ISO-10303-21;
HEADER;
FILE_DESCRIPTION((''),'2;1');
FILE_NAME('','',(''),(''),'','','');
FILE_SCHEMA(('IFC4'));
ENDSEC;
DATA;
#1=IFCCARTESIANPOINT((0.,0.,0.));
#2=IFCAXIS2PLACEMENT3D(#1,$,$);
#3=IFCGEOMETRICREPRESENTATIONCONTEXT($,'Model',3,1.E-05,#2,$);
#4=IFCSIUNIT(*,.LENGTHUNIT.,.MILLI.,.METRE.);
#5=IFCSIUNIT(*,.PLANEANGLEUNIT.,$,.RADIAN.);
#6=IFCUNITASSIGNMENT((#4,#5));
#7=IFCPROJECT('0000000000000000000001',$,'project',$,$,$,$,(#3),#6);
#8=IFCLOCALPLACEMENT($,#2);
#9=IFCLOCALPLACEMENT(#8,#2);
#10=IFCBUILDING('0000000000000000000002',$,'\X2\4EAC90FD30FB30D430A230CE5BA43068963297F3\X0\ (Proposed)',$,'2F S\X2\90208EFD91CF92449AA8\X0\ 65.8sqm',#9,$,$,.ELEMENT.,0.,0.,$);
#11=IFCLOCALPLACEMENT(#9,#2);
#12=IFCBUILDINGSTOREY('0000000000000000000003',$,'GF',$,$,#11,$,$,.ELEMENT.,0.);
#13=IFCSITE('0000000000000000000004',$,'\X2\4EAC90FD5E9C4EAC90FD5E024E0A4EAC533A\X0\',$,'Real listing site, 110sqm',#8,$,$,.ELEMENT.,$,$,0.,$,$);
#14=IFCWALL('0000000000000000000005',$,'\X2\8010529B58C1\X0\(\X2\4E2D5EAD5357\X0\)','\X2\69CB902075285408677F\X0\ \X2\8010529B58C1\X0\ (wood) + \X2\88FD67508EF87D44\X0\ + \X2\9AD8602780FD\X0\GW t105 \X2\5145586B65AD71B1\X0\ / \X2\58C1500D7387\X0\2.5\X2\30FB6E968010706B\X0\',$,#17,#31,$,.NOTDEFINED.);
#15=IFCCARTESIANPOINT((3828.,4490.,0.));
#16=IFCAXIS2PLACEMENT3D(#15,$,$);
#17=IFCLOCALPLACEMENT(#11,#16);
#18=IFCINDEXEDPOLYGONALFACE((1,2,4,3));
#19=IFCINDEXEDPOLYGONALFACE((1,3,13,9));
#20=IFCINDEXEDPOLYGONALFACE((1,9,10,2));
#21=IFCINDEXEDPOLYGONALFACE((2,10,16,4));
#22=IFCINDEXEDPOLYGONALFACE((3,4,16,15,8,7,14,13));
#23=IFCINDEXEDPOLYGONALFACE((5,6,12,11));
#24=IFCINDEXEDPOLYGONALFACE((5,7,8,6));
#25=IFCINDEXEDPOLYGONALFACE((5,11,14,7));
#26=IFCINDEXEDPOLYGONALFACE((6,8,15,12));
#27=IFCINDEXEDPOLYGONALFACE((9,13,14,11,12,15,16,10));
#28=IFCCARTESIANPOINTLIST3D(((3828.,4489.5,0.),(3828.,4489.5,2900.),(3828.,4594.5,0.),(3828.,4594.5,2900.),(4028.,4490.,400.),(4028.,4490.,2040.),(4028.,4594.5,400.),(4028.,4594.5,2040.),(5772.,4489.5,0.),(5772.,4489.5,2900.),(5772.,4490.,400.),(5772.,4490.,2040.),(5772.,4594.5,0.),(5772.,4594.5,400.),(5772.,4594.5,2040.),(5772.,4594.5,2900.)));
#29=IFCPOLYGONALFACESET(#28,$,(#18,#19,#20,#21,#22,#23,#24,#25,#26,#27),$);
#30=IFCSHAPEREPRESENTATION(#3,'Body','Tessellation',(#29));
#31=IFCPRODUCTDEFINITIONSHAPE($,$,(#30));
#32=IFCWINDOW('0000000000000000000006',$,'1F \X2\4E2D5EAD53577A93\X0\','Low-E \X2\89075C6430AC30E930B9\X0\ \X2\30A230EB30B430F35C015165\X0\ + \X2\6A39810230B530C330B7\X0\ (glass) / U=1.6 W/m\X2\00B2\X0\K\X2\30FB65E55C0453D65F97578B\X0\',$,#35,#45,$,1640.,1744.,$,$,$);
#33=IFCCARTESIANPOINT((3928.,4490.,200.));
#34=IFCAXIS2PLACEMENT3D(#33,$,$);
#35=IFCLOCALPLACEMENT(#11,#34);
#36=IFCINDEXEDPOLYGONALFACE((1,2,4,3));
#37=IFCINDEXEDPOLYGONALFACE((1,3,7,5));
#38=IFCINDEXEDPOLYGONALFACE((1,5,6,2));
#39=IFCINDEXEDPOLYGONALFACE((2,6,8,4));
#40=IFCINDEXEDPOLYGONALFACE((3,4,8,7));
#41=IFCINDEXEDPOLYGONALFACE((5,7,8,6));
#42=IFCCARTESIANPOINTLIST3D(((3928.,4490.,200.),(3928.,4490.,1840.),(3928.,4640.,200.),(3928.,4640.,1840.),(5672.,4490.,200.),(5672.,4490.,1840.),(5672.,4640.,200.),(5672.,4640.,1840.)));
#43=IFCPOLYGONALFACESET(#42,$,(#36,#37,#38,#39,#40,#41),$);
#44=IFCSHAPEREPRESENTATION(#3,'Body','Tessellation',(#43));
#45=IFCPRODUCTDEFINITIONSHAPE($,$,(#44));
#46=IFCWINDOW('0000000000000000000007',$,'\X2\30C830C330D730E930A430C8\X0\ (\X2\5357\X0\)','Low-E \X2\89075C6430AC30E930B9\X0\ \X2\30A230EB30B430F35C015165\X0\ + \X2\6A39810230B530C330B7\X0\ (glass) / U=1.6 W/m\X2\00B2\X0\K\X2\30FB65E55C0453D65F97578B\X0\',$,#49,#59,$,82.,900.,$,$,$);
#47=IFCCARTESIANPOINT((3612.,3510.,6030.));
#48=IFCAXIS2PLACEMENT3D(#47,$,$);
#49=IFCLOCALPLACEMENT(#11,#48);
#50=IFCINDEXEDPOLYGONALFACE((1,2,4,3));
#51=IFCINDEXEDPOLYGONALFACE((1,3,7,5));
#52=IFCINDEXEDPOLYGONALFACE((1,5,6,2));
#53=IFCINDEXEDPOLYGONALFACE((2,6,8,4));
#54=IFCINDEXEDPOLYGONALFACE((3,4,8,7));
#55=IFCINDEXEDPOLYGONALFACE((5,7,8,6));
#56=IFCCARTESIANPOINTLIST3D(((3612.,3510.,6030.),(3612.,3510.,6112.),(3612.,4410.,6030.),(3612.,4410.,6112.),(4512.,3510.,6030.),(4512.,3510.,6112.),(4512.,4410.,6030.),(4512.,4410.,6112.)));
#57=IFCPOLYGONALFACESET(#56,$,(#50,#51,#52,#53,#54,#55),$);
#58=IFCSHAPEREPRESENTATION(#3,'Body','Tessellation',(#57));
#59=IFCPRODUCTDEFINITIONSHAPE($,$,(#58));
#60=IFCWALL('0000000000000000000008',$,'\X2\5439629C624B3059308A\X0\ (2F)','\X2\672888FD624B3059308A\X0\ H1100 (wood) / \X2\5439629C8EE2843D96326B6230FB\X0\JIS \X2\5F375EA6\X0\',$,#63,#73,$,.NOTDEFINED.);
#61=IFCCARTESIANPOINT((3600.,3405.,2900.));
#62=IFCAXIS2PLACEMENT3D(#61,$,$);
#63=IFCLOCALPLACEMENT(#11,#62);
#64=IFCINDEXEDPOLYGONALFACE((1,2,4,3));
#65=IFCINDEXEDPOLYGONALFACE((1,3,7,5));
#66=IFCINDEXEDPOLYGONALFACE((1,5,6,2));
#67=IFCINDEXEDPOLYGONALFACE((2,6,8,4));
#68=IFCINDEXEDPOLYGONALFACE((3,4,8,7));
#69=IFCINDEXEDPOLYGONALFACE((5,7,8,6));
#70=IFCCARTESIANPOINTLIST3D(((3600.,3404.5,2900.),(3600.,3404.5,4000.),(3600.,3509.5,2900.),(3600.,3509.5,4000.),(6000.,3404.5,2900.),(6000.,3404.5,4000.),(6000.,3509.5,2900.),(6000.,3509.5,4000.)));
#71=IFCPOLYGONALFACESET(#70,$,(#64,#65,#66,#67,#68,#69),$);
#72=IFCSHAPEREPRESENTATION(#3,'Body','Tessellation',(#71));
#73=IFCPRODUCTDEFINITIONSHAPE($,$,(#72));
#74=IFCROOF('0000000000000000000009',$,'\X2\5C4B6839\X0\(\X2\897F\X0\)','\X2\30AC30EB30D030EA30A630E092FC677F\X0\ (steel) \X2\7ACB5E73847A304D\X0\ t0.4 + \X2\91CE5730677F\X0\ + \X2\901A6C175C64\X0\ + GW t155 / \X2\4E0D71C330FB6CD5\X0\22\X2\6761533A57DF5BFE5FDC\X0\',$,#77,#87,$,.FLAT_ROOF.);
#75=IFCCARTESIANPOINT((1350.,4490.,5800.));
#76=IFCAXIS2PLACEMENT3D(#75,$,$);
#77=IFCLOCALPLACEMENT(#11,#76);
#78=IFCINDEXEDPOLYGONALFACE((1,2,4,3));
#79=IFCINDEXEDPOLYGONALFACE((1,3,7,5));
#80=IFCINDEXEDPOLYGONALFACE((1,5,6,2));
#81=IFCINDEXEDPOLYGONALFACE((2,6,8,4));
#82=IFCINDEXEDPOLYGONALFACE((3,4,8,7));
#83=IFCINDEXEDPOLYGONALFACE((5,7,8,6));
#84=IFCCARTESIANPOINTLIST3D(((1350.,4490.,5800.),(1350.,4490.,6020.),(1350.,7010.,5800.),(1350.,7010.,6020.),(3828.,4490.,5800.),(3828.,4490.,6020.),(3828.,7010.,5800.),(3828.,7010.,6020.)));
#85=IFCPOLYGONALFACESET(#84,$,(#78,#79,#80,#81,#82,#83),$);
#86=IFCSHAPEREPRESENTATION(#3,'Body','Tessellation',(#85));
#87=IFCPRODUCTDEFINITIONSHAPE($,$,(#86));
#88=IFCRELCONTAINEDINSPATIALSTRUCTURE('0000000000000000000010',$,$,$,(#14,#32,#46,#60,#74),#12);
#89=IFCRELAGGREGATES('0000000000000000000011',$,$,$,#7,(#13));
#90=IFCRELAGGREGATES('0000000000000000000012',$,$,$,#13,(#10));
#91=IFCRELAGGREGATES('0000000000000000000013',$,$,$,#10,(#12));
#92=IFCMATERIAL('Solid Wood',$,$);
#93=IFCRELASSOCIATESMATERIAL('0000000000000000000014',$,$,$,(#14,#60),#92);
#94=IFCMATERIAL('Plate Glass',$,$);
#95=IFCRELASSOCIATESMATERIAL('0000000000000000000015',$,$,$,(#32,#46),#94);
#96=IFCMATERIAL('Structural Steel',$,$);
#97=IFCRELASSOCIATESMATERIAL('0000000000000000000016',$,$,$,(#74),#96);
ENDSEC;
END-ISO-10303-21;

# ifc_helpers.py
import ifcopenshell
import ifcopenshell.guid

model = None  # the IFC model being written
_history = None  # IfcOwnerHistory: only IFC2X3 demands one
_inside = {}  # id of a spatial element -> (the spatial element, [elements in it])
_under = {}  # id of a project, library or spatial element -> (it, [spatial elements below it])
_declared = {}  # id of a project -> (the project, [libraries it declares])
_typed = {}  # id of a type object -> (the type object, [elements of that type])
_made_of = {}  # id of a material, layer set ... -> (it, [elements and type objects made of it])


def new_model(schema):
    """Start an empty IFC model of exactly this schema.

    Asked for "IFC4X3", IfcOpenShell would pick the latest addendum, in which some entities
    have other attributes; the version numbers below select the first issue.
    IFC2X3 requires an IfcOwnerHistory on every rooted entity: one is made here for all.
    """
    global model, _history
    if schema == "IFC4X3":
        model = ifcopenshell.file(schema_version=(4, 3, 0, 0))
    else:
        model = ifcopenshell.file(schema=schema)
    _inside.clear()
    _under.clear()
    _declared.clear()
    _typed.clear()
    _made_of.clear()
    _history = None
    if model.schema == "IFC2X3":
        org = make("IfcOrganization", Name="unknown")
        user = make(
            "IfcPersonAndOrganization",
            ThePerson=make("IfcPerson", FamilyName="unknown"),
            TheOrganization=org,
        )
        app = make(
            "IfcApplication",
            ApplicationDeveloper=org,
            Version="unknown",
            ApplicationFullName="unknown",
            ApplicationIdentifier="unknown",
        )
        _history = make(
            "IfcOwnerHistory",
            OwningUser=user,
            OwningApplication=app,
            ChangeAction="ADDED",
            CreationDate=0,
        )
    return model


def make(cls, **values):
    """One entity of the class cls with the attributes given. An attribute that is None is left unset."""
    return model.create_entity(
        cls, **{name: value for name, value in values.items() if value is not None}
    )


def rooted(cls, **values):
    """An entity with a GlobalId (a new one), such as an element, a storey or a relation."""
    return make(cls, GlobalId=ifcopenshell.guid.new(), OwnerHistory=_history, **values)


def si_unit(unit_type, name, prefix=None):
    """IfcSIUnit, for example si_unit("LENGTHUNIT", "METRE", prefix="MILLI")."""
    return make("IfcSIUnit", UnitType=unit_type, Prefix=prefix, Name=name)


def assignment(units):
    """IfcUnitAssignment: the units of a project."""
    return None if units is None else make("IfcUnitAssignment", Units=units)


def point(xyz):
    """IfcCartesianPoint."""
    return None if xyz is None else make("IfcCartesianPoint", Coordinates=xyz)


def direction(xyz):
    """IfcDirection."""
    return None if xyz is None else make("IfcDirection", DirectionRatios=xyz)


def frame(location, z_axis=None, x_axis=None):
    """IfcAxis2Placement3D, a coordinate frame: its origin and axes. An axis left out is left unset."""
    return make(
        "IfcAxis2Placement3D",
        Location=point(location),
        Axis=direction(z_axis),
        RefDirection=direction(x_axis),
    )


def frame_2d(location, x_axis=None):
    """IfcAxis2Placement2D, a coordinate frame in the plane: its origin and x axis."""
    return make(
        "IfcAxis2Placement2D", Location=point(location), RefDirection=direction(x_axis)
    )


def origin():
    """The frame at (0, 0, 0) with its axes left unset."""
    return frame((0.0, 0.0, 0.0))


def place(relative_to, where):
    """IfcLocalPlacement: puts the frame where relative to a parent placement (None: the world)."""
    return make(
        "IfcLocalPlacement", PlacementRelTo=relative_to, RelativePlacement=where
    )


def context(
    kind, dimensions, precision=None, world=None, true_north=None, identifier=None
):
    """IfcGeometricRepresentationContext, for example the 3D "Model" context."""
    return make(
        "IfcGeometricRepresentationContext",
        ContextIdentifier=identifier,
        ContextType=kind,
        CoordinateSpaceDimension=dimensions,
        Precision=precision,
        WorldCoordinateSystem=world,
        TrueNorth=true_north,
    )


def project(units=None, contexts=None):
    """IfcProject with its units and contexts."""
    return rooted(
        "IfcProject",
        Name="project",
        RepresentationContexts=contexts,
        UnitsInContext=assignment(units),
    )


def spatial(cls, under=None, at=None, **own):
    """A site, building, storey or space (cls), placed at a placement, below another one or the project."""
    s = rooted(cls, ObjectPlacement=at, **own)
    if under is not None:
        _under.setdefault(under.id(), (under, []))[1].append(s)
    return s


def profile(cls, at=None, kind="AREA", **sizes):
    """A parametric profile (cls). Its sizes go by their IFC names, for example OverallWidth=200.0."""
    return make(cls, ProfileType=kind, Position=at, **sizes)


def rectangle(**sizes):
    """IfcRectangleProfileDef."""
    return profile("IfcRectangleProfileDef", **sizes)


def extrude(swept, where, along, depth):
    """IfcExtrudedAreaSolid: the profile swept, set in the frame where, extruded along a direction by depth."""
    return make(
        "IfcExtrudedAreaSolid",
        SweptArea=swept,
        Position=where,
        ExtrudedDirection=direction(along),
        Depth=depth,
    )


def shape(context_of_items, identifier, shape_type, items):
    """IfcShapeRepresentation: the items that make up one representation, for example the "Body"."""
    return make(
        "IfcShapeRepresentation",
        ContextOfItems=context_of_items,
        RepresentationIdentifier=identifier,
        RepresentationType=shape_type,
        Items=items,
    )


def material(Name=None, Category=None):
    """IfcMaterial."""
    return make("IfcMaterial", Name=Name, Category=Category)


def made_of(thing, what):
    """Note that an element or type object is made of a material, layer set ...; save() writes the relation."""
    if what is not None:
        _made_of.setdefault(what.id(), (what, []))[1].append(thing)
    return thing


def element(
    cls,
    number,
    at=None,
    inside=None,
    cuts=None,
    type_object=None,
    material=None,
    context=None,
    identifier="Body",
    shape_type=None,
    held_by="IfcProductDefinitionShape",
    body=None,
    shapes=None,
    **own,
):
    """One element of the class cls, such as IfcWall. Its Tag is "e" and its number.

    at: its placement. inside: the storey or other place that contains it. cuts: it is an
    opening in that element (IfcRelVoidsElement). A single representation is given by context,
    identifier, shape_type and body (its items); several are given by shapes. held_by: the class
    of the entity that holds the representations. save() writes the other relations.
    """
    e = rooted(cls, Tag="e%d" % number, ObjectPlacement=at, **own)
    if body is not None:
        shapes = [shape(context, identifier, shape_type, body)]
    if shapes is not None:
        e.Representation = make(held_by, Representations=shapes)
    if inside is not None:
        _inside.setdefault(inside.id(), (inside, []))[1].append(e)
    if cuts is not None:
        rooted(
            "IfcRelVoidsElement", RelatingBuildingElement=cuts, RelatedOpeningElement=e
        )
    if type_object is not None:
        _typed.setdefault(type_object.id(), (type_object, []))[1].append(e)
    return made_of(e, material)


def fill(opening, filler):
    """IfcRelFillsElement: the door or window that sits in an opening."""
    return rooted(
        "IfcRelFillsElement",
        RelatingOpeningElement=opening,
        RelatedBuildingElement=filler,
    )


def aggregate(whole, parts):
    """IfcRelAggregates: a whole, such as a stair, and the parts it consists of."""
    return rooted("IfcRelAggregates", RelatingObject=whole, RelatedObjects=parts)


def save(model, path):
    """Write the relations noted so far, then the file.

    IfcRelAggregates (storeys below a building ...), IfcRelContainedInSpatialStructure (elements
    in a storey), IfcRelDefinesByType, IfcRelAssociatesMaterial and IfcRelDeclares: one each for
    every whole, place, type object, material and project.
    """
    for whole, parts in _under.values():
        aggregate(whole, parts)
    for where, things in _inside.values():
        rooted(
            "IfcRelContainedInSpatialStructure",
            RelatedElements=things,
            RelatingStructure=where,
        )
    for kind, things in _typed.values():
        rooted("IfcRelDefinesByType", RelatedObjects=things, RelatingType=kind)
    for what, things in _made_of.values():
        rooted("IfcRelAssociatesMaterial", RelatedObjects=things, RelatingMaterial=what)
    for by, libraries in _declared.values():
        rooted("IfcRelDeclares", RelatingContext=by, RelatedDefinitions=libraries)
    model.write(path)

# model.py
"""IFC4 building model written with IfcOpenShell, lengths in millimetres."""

from ifc_helpers import new_model, si_unit, frame, frame_2d, origin, place, context, project, spatial, rectangle, extrude, material, element, fill, save


model = new_model("IFC4")

# Units and contexts
model_context = context("Model", 3, precision=1e-05, world=origin())
ifc_project = project(units=[si_unit("LENGTHUNIT", "METRE", prefix="MILLI"), si_unit("PLANEANGLEUNIT", "RADIAN")], contexts=[model_context])

# Site, building, storey
site_placement = place(None, origin())
site = spatial("IfcSite", under=ifc_project, at=site_placement, Name="京都府京都市上京区", ObjectType="Real listing site, 110sqm", CompositionType="ELEMENT", RefElevation=0.0)
building_placement = place(site_placement, origin())
building = spatial("IfcBuilding", under=site, at=building_placement, Name="京都・ピアノ室と防音 (Proposed)", ObjectType="2F S造軽量鉄骨 65.8sqm", CompositionType="ELEMENT", ElevationOfRefHeight=0.0, ElevationOfTerrain=0.0)
storey_placement = place(building_placement, origin())
storey = spatial("IfcBuildingStorey", under=building, at=storey_placement, Name="GF", CompositionType="ELEMENT", Elevation=0.0)

# Shared definitions
ifc_material_1 = material(Name="Solid Wood")

# Wall, opening, window
wall_1_placement = place(storey_placement, frame((3828.0, 4490.0, 0.0)))
wall_1 = element("IfcWall", 1, at=wall_1_placement, inside=storey, material=ifc_material_1, Name="耐力壁(中庭南)", Description="構造用合板 耐力壁 (wood) + 製材軸組 + 高性能GW t105 充填断熱 / 壁倍率2.5・準耐火", PredefinedType="NOTDEFINED", context=model_context, shape_type="SweptSolid", body=[
    extrude(rectangle(XDim=1944.0, YDim=105.0, at=frame_2d((972.0, 52.0))), frame((3828.0, 4490.0, 0.0)), (0.0, 0.0, 1.0), 2900.0),
])
opening_placement = place(storey_placement, frame((3928.0, 4490.0, 200.0)))
opening = element("IfcOpeningElement", 2, at=opening_placement, cuts=wall_1, PredefinedType="NOTDEFINED", context=model_context, shape_type="SweptSolid", body=[
    extrude(rectangle(XDim=1744.0, YDim=150.0, at=frame_2d((872.0, 75.0))), frame((3928.0, 4490.0, 200.0)), (0.0, 0.0, 1.0), 1640.0),
])
ifc_material_2 = material(Name="Plate Glass")
window_1_placement = place(storey_placement, frame((3928.0, 4490.0, 200.0)))
window_1 = element("IfcWindow", 3, at=window_1_placement, inside=storey, material=ifc_material_2, Name="1F 中庭南窓", Description="Low-E 複層ガラス アルゴン封入 + 樹脂サッシ (glass) / U=1.6 W/m²K・日射取得型", OverallHeight=1640.0, OverallWidth=1744.0, context=model_context, shape_type="SweptSolid", body=[
    extrude(rectangle(XDim=1744.0, YDim=150.0, at=frame_2d((872.0, 75.0))), frame((3928.0, 4490.0, 200.0)), (0.0, 0.0, 1.0), 1640.0),
])
fill(opening, window_1)

# Window
window_2_placement = place(storey_placement, frame((3612.0, 3510.0, 6030.0)))
element("IfcWindow", 4, at=window_2_placement, inside=storey, material=ifc_material_2, Name="トップライト (南)", Description="Low-E 複層ガラス アルゴン封入 + 樹脂サッシ (glass) / U=1.6 W/m²K・日射取得型", OverallHeight=82.0, OverallWidth=900.0, context=model_context, shape_type="SweptSolid", body=[
    extrude(rectangle(XDim=900.0, YDim=900.0, at=frame_2d((450.0, 450.0))), frame((3612.0, 3510.0, 6030.0)), (0.0, 0.0, 1.0), 82.0),
])

# Wall
wall_2_placement = place(storey_placement, frame((3600.0, 3405.0, 2900.0)))
element("IfcWall", 5, at=wall_2_placement, inside=storey, material=ifc_material_1, Name="吹抜手すり (2F)", Description="木製手すり H1100 (wood) / 吹抜転落防止・JIS 強度", PredefinedType="NOTDEFINED", context=model_context, shape_type="SweptSolid", body=[
    extrude(rectangle(XDim=2400.0, YDim=105.0, at=frame_2d((1200.0, 52.0))), frame((3600.0, 3405.0, 2900.0)), (0.0, 0.0, 1.0), 1100.0),
])

# Roof
ifc_material_3 = material(Name="Structural Steel")
for number, where, name in (
    (6, (1350.0, 4490.0, 5800.0), "屋根(西)"),
):
    element("IfcRoof", number, at=place(storey_placement, frame(where)), inside=storey, material=ifc_material_3, Name=name, Description="ガルバリウム鋼板 (steel) 立平葺き t0.4 + 野地板 + 通気層 + GW t155 / 不燃・法22条区域対応", PredefinedType="FLAT_ROOF", context=model_context, shape_type="SweptSolid", body=[
        extrude(rectangle(XDim=2478.0, YDim=2520.0, at=frame_2d((1239.0, 1260.0))), frame((1350.0, 4490.0, 5800.0)), (0.0, 0.0, 1.0), 220.0),
    ])

save(model, "model.ifc")
